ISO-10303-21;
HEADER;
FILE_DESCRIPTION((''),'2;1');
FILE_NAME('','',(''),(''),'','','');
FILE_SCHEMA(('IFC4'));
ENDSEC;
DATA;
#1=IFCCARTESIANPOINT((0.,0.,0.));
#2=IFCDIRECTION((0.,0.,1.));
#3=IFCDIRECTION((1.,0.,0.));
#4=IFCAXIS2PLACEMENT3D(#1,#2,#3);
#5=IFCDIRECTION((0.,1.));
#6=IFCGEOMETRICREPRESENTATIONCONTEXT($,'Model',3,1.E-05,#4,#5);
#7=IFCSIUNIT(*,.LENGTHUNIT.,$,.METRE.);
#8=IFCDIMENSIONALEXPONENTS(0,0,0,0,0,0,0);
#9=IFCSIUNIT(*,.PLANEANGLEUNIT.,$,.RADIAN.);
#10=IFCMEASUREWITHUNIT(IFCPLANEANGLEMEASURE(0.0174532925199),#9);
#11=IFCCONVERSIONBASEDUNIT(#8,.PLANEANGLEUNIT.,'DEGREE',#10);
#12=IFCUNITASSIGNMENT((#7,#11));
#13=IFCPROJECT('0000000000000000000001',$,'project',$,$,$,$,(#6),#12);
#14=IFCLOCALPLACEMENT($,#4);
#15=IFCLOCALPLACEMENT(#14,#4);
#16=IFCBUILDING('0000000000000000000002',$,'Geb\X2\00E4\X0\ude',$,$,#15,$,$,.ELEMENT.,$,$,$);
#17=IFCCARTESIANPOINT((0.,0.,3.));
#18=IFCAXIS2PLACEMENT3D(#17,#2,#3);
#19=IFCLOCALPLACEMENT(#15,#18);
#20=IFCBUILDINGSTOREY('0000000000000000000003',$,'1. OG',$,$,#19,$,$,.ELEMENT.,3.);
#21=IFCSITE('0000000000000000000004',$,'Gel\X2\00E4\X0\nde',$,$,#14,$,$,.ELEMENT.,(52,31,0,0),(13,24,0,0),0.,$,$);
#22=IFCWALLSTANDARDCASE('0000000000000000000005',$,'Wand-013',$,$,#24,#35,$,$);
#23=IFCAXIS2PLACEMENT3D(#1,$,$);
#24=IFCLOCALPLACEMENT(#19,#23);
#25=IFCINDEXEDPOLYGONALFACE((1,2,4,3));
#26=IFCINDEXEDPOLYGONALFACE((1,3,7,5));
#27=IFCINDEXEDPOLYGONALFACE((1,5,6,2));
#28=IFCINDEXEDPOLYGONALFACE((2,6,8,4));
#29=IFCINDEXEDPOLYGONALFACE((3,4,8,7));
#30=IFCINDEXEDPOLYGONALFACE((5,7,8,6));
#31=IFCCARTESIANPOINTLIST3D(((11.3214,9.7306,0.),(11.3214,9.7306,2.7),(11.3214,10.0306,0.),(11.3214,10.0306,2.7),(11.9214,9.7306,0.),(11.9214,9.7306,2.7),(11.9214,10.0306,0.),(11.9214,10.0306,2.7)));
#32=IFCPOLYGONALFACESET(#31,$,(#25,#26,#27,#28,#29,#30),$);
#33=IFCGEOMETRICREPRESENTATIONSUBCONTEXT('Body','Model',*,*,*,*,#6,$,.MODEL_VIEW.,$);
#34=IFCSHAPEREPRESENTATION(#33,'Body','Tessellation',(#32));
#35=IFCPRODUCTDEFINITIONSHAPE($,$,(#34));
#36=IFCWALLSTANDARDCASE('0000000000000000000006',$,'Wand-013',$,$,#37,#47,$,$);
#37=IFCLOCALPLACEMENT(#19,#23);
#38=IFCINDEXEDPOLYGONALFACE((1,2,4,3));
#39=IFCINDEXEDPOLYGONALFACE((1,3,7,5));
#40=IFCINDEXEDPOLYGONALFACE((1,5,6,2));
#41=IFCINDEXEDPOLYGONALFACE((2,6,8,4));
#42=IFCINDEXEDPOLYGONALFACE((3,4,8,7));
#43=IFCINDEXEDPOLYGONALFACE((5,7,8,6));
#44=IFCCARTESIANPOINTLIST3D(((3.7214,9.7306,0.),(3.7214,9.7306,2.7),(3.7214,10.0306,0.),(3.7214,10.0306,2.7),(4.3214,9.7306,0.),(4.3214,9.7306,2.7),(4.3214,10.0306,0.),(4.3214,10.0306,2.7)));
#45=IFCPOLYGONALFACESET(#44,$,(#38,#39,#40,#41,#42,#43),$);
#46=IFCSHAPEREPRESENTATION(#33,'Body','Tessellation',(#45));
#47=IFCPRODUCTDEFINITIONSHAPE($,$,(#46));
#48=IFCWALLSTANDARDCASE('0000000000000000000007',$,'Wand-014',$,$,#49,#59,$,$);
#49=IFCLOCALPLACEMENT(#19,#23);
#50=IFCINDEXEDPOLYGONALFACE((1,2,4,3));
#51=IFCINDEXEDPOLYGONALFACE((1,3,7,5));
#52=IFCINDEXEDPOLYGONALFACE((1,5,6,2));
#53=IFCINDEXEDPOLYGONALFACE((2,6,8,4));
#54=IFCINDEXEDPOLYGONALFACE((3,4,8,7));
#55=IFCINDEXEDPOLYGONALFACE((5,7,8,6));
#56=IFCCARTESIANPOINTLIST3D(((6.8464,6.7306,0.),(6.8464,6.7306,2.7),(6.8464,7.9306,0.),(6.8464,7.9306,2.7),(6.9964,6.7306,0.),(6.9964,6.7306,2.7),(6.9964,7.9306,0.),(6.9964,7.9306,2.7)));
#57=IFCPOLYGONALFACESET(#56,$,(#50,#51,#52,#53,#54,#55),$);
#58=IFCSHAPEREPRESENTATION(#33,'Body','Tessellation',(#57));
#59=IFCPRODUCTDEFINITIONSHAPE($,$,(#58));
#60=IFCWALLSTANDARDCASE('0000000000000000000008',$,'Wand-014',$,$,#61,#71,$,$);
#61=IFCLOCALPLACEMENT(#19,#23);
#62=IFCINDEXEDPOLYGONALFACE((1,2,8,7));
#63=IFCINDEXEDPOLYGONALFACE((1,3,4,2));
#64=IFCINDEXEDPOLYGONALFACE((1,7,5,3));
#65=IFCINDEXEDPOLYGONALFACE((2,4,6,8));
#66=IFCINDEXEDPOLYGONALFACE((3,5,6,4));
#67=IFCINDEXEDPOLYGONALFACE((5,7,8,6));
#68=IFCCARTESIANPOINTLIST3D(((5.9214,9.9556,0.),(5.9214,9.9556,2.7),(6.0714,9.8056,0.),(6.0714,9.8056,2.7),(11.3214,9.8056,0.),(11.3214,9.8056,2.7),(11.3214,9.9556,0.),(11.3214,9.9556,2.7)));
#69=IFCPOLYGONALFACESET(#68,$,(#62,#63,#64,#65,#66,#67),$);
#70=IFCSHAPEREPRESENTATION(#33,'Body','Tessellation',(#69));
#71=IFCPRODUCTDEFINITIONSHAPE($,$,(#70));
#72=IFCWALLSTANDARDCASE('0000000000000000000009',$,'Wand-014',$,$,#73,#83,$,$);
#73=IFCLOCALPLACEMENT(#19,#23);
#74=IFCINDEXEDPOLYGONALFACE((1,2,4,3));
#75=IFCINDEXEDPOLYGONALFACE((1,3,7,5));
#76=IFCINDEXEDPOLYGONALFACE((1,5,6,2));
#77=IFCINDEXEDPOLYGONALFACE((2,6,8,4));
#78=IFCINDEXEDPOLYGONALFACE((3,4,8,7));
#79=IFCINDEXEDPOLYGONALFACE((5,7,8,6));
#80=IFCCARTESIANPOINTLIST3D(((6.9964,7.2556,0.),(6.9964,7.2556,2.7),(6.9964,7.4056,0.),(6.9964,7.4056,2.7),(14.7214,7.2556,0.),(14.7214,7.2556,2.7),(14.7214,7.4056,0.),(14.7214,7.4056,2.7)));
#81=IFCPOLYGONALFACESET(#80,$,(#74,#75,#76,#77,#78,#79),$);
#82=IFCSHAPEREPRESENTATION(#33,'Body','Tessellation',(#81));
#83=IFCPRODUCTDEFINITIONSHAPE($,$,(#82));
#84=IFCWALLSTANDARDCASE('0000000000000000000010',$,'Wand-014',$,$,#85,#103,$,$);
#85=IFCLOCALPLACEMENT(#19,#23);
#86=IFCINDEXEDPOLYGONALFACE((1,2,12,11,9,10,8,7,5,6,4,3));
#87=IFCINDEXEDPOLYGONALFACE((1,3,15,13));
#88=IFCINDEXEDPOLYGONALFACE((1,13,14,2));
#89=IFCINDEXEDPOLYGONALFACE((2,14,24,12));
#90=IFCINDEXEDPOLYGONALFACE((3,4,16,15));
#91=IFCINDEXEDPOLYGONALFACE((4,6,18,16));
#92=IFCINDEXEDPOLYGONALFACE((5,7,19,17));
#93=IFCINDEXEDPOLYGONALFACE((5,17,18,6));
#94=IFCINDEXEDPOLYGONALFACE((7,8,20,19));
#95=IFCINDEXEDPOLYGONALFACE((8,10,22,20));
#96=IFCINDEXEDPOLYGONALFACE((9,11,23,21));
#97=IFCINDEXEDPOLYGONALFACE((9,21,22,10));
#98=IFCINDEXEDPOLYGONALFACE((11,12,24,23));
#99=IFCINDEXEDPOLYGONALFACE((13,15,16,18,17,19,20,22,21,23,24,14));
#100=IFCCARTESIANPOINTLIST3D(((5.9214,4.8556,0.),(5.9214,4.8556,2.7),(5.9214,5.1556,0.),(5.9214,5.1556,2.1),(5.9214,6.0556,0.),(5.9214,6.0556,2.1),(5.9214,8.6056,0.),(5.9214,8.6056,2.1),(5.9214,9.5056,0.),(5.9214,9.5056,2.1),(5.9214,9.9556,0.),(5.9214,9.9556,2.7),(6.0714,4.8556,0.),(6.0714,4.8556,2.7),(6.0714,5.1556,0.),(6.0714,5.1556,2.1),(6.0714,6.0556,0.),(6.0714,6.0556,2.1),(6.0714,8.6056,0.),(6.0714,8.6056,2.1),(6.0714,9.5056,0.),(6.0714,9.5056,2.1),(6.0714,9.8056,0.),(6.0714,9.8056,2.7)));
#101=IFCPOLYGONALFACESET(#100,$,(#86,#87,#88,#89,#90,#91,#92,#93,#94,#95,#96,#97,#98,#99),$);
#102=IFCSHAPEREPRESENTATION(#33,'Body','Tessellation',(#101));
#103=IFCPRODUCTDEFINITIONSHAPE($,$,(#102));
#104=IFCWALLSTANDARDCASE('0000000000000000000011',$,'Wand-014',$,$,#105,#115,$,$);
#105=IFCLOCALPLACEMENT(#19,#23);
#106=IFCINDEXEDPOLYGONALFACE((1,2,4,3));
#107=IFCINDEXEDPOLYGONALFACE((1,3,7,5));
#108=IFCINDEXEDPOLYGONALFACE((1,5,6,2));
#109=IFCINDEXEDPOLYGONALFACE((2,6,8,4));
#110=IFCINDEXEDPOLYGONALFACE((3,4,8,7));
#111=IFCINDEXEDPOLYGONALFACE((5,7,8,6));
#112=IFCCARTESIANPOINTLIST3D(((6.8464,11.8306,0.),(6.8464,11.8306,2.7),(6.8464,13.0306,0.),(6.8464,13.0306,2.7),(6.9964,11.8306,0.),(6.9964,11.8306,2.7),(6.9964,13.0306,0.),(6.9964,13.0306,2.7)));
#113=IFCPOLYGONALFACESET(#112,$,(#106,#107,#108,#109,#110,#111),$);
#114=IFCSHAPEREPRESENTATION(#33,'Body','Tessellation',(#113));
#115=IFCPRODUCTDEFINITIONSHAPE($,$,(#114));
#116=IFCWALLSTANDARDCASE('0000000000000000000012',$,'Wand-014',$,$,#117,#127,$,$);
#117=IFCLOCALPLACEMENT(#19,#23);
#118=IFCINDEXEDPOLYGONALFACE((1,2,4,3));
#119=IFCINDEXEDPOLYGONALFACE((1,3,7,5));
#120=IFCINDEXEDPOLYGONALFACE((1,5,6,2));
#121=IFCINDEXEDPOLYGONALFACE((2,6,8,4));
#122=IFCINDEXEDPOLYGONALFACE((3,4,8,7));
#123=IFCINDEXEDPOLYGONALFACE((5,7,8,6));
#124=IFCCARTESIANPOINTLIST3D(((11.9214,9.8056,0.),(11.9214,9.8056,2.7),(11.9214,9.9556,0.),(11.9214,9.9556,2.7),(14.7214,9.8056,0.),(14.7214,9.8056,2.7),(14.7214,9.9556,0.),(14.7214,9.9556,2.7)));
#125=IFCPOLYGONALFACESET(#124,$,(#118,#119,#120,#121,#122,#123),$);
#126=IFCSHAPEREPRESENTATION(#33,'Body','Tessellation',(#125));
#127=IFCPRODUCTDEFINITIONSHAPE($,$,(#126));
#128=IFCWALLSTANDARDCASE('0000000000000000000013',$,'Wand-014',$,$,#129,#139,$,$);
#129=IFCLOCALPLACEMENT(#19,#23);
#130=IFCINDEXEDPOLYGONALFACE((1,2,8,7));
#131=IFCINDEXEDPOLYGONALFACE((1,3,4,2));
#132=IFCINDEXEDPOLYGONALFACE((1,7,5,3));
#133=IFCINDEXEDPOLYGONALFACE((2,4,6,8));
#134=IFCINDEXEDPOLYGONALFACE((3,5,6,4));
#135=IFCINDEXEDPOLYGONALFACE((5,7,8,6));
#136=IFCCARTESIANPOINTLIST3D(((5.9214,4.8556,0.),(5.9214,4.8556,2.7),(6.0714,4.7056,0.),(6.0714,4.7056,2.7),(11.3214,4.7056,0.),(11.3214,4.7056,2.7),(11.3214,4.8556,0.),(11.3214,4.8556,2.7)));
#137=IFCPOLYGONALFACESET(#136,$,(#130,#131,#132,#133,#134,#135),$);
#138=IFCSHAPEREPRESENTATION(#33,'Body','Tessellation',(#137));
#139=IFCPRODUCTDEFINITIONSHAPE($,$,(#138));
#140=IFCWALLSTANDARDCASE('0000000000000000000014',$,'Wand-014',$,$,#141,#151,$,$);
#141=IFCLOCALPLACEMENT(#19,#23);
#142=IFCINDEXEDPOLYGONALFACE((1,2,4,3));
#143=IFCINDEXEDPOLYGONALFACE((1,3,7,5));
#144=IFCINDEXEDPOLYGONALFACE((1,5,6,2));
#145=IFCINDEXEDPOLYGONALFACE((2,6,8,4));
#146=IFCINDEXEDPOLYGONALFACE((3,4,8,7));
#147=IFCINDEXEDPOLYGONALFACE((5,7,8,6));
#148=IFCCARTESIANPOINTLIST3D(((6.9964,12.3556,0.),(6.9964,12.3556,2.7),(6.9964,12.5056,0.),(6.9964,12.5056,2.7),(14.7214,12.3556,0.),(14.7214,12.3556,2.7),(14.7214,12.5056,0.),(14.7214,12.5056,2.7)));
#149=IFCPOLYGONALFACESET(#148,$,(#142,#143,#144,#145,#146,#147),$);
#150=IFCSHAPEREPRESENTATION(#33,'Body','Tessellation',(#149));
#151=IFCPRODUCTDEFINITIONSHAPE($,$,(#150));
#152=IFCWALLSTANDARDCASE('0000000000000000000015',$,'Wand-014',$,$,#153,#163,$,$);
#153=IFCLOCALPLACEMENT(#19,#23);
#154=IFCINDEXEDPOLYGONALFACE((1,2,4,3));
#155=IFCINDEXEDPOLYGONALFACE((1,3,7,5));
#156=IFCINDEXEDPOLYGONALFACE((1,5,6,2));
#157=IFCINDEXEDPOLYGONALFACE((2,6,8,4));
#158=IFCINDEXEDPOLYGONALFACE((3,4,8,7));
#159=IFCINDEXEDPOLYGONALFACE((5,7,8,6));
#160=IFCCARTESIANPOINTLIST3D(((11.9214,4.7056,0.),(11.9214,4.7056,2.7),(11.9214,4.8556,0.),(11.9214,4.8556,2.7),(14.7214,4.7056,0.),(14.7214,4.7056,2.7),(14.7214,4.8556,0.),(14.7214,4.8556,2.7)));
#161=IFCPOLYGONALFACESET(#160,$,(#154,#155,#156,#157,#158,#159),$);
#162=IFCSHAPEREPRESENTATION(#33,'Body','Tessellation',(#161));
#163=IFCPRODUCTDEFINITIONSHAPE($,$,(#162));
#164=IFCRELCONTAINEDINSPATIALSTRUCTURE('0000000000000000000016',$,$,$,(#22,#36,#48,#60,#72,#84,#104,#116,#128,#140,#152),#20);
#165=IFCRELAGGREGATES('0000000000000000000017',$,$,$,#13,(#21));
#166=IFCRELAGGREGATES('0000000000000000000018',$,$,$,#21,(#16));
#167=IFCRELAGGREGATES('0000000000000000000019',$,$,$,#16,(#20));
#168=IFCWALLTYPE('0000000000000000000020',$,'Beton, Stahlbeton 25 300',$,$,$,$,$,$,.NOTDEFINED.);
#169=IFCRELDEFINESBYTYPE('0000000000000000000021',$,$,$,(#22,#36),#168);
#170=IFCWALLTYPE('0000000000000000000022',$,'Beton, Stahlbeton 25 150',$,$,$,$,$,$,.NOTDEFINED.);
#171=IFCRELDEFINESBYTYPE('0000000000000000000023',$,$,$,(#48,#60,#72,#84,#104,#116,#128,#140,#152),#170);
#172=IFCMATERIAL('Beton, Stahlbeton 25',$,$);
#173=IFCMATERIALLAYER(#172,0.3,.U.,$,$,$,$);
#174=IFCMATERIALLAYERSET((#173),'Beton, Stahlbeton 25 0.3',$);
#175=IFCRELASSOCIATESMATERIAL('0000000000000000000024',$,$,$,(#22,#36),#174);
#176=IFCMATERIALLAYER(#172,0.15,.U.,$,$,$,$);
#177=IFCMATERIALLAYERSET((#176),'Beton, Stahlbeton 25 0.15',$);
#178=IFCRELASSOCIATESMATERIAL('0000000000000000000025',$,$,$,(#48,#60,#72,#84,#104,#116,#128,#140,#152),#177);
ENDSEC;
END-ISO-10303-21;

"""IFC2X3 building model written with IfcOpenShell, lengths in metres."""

from ifc_helpers import new_model, entity, si_unit, converted_unit, direction, frame, origin_with_axes, origin_2d_with_axis, place, context, subcontext, project, spatial, polyline, rectangle, outline, extrude, material, layer, layer_set, layer_usage, type_object, element, save


model = new_model("IFC2X3")

# Units and contexts
model_context = context("Model", 3, precision=1e-05, world=origin_with_axes(), true_north=direction((0.0, 1.0)))
body_context = subcontext(model_context, "Body", "Model", "MODEL_VIEW")
ifc_project = project(units=[si_unit("LENGTHUNIT", "METRE"), converted_unit("PLANEANGLEUNIT", "DEGREE", entity("IfcPlaneAngleMeasure", 0.0174532925199), si_unit("PLANEANGLEUNIT", "RADIAN"), dimensions=[0, 0, 0, 0, 0, 0, 0])], contexts=[model_context])

# Site, building, storey
site_placement = place(None, origin_with_axes())
site = spatial("IfcSite", under=ifc_project, at=site_placement, Name="Gelände", CompositionType="ELEMENT", RefLatitude=(52, 31, 0, 0), RefLongitude=(13, 24, 0, 0), RefElevation=0.0)
building_placement = place(site_placement, origin_with_axes())
building = spatial("IfcBuilding", under=site, at=building_placement, Name="Gebäude", CompositionType="ELEMENT")
storey_placement = place(building_placement, frame((0.0, 0.0, 3.0), z_axis=(0.0, 0.0, 1.0), x_axis=(1.0, 0.0, 0.0)))
storey = spatial("IfcBuildingStorey", under=building, at=storey_placement, Name="1. OG", CompositionType="ELEMENT", Elevation=3.0)

# Walls
ifc_material = material(Name="Beton, Stahlbeton 25")
ifc_layer_1 = layer(ifc_material, 0.3, ventilated="UNKNOWN")
ifc_layer_set_1 = layer_set([ifc_layer_1], Name="Beton, Stahlbeton 25 0.3")
ifc_layer_usage_1 = layer_usage(ifc_layer_set_1, "AXIS2", "NEGATIVE", 0.3)
wall_type_1 = type_object("IfcWallType", Name="Beton, Stahlbeton 25 300", PredefinedType="NOTDEFINED")
wall_1_placement = place(storey_placement, frame((11.3214, 9.7306, 0.0), z_axis=(0.0, 0.0, 1.0), x_axis=(1.0, 0.0, 0.0)))
element("IfcWallStandardCase", 1, at=wall_1_placement, inside=storey, type_object=wall_type_1, material=ifc_layer_usage_1, Name="Wand-013", context=body_context, shape_type="SweptSolid", body=[
    extrude(outline(polyline([(0.0, 0.0), (0.6, 0.0), (0.6, 0.3), (0.0, 0.3), (0.0, 0.0)])), origin_with_axes(), (0.0, 0.0, 1.0), 2.7),
])
ifc_layer_usage_2 = layer_usage(ifc_layer_set_1, "AXIS2", "NEGATIVE", 0.3)
wall_2_placement = place(storey_placement, frame((3.7214, 9.7306, 0.0), z_axis=(0.0, 0.0, 1.0), x_axis=(1.0, 0.0, 0.0)))
element("IfcWallStandardCase", 2, at=wall_2_placement, inside=storey, type_object=wall_type_1, material=ifc_layer_usage_2, Name="Wand-013", context=body_context, shape_type="SweptSolid", body=[
    extrude(outline(polyline([(0.0, 0.0), (0.6, 0.0), (0.6, 0.3), (0.0, 0.3), (0.0, 0.0)])), origin_with_axes(), (0.0, 0.0, 1.0), 2.7),
])
ifc_layer_2 = layer(ifc_material, 0.15, ventilated="UNKNOWN")
ifc_layer_set_2 = layer_set([ifc_layer_2], Name="Beton, Stahlbeton 25 0.15")
ifc_layer_usage_3 = layer_usage(ifc_layer_set_2, "AXIS2", "POSITIVE", 0.0)
wall_type_2 = type_object("IfcWallType", Name="Beton, Stahlbeton 25 150", PredefinedType="NOTDEFINED")
wall_3_placement = place(storey_placement, frame((6.9964, 6.7306, 0.0), z_axis=(0.0, 0.0, 1.0), x_axis=(0.0, 1.0, 0.0)))
element("IfcWallStandardCase", 3, at=wall_3_placement, inside=storey, type_object=wall_type_2, material=ifc_layer_usage_3, Name="Wand-014", context=body_context, shape_type="SweptSolid", body=[
    extrude(outline(polyline([(0.0, 0.0), (1.2, 0.0), (1.2, 0.15), (0.0, 0.15), (0.0, 0.0)])), origin_with_axes(), (0.0, 0.0, 1.0), 2.7),
])
ifc_layer_usage_4 = layer_usage(ifc_layer_set_2, "AXIS2", "NEGATIVE", 0.075)
wall_4_placement = place(storey_placement, frame((11.3214, 9.8806, 0.0), z_axis=(0.0, 0.0, 1.0), x_axis=(-1.0, 0.0, 0.0)))
element("IfcWallStandardCase", 4, at=wall_4_placement, inside=storey, type_object=wall_type_2, material=ifc_layer_usage_4, Name="Wand-014", context=body_context, shape_type="SweptSolid", body=[
    extrude(outline(polyline([(0.0, -0.075), (5.4, -0.075), (5.25, 0.075), (0.0, 0.075), (0.0, -0.075)])), origin_with_axes(), (0.0, 0.0, 1.0), 2.7),
])
ifc_layer_usage_5 = layer_usage(ifc_layer_set_2, "AXIS2", "NEGATIVE", 0.075)
wall_5_placement = place(storey_placement, frame((14.7214, 7.3306, 0.0), z_axis=(0.0, 0.0, 1.0), x_axis=(-1.0, 0.0, 0.0)))
element("IfcWallStandardCase", 5, at=wall_5_placement, inside=storey, type_object=wall_type_2, material=ifc_layer_usage_5, Name="Wand-014", context=body_context, shape_type="SweptSolid", body=[
    extrude(outline(polyline([(0.0, -0.075), (7.725, -0.075), (7.725, 0.075), (0.0, 0.075), (0.0, -0.075)])), origin_with_axes(), (0.0, 0.0, 1.0), 2.7),
])

# Wall, openings
ifc_layer_usage_6 = layer_usage(ifc_layer_set_2, "AXIS2", "POSITIVE", 0.0)
wall_6_placement = place(storey_placement, frame((5.9214, 9.8806, 0.0), z_axis=(0.0, 0.0, 1.0), x_axis=(0.0, -1.0, 0.0)))
wall_6 = element("IfcWallStandardCase", 6, at=wall_6_placement, inside=storey, type_object=wall_type_2, material=ifc_layer_usage_6, Name="Wand-014", context=body_context, shape_type="SweptSolid", body=[
    extrude(outline(polyline([(-0.075, 0.0), (5.025, 0.0), (5.025, 0.15), (0.075, 0.15), (-0.075, 0.0)])), origin_with_axes(), (0.0, 0.0, 1.0), 2.7),
])
opening_1_placement = place(wall_6_placement, frame((0.825, 0.0, 0.0), z_axis=(0.0, 0.0, 1.0), x_axis=(1.0, 0.0, 0.0)))
element("IfcOpeningElement", 7, at=opening_1_placement, cuts=wall_6, context=body_context, shape_type="SweptSolid", body=[
    extrude(rectangle(XDim=0.9, YDim=2.1, at=origin_2d_with_axis()), frame((0.0, 0.3, 1.05), z_axis=(0.0, -1.0, 0.0), x_axis=(1.0, 0.0, 0.0)), (0.0, 0.0, 1.0), 0.15),
    extrude(rectangle(XDim=0.9, YDim=2.1, at=origin_2d_with_axis()), frame((0.0, 0.0, 1.05), z_axis=(0.0, 1.0, 0.0), x_axis=(1.0, 0.0, 0.0)), (0.0, 0.0, 1.0), 0.15),
])
opening_2_placement = place(wall_6_placement, frame((4.275, 0.0, 0.0), z_axis=(0.0, 0.0, 1.0), x_axis=(1.0, 0.0, 0.0)))
element("IfcOpeningElement", 8, at=opening_2_placement, cuts=wall_6, context=body_context, shape_type="SweptSolid", body=[
    extrude(rectangle(XDim=0.9, YDim=2.1, at=origin_2d_with_axis()), frame((0.0, 0.3, 1.05), z_axis=(0.0, -1.0, 0.0), x_axis=(1.0, 0.0, 0.0)), (0.0, 0.0, 1.0), 0.15),
    extrude(rectangle(XDim=0.9, YDim=2.1, at=origin_2d_with_axis()), frame((0.0, 0.0, 1.05), z_axis=(0.0, 1.0, 0.0), x_axis=(1.0, 0.0, 0.0)), (0.0, 0.0, 1.0), 0.15),
])

# Walls
ifc_layer_usage_7 = layer_usage(ifc_layer_set_2, "AXIS2", "POSITIVE", 0.0)
wall_7_placement = place(storey_placement, frame((6.9964, 11.8306, 0.0), z_axis=(0.0, 0.0, 1.0), x_axis=(0.0, 1.0, 0.0)))
element("IfcWallStandardCase", 9, at=wall_7_placement, inside=storey, type_object=wall_type_2, material=ifc_layer_usage_7, Name="Wand-014", context=body_context, shape_type="SweptSolid", body=[
    extrude(outline(polyline([(0.0, 0.0), (1.2, 0.0), (1.2, 0.15), (0.0, 0.15), (0.0, 0.0)])), origin_with_axes(), (0.0, 0.0, 1.0), 2.7),
])
ifc_layer_usage_8 = layer_usage(ifc_layer_set_2, "AXIS2", "NEGATIVE", 0.075)
wall_8_placement = place(storey_placement, frame((14.7214, 9.8806, 0.0), z_axis=(0.0, 0.0, 1.0), x_axis=(-1.0, 0.0, 0.0)))
element("IfcWallStandardCase", 10, at=wall_8_placement, inside=storey, type_object=wall_type_2, material=ifc_layer_usage_8, Name="Wand-014", context=body_context, shape_type="SweptSolid", body=[
    extrude(outline(polyline([(0.0, -0.075), (2.8, -0.075), (2.8, 0.075), (0.0, 0.075), (0.0, -0.075)])), origin_with_axes(), (0.0, 0.0, 1.0), 2.7),
])
ifc_layer_usage_9 = layer_usage(ifc_layer_set_2, "AXIS2", "NEGATIVE", 0.075)
wall_9_placement = place(storey_placement, frame((11.3214, 4.7806, 0.0), z_axis=(0.0, 0.0, 1.0), x_axis=(-1.0, 0.0, 0.0)))
element("IfcWallStandardCase", 11, at=wall_9_placement, inside=storey, type_object=wall_type_2, material=ifc_layer_usage_9, Name="Wand-014", context=body_context, shape_type="SweptSolid", body=[
    extrude(outline(polyline([(0.0, -0.075), (5.4, -0.075), (5.25, 0.075), (0.0, 0.075), (0.0, -0.075)])), origin_with_axes(), (0.0, 0.0, 1.0), 2.7),
])
ifc_layer_usage_10 = layer_usage(ifc_layer_set_2, "AXIS2", "NEGATIVE", 0.075)
wall_10_placement = place(storey_placement, frame((14.7214, 12.4306, 0.0), z_axis=(0.0, 0.0, 1.0), x_axis=(-1.0, 0.0, 0.0)))
element("IfcWallStandardCase", 12, at=wall_10_placement, inside=storey, type_object=wall_type_2, material=ifc_layer_usage_10, Name="Wand-014", context=body_context, shape_type="SweptSolid", body=[
    extrude(outline(polyline([(0.0, -0.075), (7.725, -0.075), (7.725, 0.075), (0.0, 0.075), (0.0, -0.075)])), origin_with_axes(), (0.0, 0.0, 1.0), 2.7),
])
ifc_layer_usage_11 = layer_usage(ifc_layer_set_2, "AXIS2", "NEGATIVE", 0.075)
wall_11_placement = place(storey_placement, frame((14.7214, 4.7806, 0.0), z_axis=(0.0, 0.0, 1.0), x_axis=(-1.0, 0.0, 0.0)))
element("IfcWallStandardCase", 13, at=wall_11_placement, inside=storey, type_object=wall_type_2, material=ifc_layer_usage_11, Name="Wand-014", context=body_context, shape_type="SweptSolid", body=[
    extrude(outline(polyline([(0.0, -0.075), (2.8, -0.075), (2.8, 0.075), (0.0, 0.075), (0.0, -0.075)])), origin_with_axes(), (0.0, 0.0, 1.0), 2.7),
])

save(model, "model.ifc")
